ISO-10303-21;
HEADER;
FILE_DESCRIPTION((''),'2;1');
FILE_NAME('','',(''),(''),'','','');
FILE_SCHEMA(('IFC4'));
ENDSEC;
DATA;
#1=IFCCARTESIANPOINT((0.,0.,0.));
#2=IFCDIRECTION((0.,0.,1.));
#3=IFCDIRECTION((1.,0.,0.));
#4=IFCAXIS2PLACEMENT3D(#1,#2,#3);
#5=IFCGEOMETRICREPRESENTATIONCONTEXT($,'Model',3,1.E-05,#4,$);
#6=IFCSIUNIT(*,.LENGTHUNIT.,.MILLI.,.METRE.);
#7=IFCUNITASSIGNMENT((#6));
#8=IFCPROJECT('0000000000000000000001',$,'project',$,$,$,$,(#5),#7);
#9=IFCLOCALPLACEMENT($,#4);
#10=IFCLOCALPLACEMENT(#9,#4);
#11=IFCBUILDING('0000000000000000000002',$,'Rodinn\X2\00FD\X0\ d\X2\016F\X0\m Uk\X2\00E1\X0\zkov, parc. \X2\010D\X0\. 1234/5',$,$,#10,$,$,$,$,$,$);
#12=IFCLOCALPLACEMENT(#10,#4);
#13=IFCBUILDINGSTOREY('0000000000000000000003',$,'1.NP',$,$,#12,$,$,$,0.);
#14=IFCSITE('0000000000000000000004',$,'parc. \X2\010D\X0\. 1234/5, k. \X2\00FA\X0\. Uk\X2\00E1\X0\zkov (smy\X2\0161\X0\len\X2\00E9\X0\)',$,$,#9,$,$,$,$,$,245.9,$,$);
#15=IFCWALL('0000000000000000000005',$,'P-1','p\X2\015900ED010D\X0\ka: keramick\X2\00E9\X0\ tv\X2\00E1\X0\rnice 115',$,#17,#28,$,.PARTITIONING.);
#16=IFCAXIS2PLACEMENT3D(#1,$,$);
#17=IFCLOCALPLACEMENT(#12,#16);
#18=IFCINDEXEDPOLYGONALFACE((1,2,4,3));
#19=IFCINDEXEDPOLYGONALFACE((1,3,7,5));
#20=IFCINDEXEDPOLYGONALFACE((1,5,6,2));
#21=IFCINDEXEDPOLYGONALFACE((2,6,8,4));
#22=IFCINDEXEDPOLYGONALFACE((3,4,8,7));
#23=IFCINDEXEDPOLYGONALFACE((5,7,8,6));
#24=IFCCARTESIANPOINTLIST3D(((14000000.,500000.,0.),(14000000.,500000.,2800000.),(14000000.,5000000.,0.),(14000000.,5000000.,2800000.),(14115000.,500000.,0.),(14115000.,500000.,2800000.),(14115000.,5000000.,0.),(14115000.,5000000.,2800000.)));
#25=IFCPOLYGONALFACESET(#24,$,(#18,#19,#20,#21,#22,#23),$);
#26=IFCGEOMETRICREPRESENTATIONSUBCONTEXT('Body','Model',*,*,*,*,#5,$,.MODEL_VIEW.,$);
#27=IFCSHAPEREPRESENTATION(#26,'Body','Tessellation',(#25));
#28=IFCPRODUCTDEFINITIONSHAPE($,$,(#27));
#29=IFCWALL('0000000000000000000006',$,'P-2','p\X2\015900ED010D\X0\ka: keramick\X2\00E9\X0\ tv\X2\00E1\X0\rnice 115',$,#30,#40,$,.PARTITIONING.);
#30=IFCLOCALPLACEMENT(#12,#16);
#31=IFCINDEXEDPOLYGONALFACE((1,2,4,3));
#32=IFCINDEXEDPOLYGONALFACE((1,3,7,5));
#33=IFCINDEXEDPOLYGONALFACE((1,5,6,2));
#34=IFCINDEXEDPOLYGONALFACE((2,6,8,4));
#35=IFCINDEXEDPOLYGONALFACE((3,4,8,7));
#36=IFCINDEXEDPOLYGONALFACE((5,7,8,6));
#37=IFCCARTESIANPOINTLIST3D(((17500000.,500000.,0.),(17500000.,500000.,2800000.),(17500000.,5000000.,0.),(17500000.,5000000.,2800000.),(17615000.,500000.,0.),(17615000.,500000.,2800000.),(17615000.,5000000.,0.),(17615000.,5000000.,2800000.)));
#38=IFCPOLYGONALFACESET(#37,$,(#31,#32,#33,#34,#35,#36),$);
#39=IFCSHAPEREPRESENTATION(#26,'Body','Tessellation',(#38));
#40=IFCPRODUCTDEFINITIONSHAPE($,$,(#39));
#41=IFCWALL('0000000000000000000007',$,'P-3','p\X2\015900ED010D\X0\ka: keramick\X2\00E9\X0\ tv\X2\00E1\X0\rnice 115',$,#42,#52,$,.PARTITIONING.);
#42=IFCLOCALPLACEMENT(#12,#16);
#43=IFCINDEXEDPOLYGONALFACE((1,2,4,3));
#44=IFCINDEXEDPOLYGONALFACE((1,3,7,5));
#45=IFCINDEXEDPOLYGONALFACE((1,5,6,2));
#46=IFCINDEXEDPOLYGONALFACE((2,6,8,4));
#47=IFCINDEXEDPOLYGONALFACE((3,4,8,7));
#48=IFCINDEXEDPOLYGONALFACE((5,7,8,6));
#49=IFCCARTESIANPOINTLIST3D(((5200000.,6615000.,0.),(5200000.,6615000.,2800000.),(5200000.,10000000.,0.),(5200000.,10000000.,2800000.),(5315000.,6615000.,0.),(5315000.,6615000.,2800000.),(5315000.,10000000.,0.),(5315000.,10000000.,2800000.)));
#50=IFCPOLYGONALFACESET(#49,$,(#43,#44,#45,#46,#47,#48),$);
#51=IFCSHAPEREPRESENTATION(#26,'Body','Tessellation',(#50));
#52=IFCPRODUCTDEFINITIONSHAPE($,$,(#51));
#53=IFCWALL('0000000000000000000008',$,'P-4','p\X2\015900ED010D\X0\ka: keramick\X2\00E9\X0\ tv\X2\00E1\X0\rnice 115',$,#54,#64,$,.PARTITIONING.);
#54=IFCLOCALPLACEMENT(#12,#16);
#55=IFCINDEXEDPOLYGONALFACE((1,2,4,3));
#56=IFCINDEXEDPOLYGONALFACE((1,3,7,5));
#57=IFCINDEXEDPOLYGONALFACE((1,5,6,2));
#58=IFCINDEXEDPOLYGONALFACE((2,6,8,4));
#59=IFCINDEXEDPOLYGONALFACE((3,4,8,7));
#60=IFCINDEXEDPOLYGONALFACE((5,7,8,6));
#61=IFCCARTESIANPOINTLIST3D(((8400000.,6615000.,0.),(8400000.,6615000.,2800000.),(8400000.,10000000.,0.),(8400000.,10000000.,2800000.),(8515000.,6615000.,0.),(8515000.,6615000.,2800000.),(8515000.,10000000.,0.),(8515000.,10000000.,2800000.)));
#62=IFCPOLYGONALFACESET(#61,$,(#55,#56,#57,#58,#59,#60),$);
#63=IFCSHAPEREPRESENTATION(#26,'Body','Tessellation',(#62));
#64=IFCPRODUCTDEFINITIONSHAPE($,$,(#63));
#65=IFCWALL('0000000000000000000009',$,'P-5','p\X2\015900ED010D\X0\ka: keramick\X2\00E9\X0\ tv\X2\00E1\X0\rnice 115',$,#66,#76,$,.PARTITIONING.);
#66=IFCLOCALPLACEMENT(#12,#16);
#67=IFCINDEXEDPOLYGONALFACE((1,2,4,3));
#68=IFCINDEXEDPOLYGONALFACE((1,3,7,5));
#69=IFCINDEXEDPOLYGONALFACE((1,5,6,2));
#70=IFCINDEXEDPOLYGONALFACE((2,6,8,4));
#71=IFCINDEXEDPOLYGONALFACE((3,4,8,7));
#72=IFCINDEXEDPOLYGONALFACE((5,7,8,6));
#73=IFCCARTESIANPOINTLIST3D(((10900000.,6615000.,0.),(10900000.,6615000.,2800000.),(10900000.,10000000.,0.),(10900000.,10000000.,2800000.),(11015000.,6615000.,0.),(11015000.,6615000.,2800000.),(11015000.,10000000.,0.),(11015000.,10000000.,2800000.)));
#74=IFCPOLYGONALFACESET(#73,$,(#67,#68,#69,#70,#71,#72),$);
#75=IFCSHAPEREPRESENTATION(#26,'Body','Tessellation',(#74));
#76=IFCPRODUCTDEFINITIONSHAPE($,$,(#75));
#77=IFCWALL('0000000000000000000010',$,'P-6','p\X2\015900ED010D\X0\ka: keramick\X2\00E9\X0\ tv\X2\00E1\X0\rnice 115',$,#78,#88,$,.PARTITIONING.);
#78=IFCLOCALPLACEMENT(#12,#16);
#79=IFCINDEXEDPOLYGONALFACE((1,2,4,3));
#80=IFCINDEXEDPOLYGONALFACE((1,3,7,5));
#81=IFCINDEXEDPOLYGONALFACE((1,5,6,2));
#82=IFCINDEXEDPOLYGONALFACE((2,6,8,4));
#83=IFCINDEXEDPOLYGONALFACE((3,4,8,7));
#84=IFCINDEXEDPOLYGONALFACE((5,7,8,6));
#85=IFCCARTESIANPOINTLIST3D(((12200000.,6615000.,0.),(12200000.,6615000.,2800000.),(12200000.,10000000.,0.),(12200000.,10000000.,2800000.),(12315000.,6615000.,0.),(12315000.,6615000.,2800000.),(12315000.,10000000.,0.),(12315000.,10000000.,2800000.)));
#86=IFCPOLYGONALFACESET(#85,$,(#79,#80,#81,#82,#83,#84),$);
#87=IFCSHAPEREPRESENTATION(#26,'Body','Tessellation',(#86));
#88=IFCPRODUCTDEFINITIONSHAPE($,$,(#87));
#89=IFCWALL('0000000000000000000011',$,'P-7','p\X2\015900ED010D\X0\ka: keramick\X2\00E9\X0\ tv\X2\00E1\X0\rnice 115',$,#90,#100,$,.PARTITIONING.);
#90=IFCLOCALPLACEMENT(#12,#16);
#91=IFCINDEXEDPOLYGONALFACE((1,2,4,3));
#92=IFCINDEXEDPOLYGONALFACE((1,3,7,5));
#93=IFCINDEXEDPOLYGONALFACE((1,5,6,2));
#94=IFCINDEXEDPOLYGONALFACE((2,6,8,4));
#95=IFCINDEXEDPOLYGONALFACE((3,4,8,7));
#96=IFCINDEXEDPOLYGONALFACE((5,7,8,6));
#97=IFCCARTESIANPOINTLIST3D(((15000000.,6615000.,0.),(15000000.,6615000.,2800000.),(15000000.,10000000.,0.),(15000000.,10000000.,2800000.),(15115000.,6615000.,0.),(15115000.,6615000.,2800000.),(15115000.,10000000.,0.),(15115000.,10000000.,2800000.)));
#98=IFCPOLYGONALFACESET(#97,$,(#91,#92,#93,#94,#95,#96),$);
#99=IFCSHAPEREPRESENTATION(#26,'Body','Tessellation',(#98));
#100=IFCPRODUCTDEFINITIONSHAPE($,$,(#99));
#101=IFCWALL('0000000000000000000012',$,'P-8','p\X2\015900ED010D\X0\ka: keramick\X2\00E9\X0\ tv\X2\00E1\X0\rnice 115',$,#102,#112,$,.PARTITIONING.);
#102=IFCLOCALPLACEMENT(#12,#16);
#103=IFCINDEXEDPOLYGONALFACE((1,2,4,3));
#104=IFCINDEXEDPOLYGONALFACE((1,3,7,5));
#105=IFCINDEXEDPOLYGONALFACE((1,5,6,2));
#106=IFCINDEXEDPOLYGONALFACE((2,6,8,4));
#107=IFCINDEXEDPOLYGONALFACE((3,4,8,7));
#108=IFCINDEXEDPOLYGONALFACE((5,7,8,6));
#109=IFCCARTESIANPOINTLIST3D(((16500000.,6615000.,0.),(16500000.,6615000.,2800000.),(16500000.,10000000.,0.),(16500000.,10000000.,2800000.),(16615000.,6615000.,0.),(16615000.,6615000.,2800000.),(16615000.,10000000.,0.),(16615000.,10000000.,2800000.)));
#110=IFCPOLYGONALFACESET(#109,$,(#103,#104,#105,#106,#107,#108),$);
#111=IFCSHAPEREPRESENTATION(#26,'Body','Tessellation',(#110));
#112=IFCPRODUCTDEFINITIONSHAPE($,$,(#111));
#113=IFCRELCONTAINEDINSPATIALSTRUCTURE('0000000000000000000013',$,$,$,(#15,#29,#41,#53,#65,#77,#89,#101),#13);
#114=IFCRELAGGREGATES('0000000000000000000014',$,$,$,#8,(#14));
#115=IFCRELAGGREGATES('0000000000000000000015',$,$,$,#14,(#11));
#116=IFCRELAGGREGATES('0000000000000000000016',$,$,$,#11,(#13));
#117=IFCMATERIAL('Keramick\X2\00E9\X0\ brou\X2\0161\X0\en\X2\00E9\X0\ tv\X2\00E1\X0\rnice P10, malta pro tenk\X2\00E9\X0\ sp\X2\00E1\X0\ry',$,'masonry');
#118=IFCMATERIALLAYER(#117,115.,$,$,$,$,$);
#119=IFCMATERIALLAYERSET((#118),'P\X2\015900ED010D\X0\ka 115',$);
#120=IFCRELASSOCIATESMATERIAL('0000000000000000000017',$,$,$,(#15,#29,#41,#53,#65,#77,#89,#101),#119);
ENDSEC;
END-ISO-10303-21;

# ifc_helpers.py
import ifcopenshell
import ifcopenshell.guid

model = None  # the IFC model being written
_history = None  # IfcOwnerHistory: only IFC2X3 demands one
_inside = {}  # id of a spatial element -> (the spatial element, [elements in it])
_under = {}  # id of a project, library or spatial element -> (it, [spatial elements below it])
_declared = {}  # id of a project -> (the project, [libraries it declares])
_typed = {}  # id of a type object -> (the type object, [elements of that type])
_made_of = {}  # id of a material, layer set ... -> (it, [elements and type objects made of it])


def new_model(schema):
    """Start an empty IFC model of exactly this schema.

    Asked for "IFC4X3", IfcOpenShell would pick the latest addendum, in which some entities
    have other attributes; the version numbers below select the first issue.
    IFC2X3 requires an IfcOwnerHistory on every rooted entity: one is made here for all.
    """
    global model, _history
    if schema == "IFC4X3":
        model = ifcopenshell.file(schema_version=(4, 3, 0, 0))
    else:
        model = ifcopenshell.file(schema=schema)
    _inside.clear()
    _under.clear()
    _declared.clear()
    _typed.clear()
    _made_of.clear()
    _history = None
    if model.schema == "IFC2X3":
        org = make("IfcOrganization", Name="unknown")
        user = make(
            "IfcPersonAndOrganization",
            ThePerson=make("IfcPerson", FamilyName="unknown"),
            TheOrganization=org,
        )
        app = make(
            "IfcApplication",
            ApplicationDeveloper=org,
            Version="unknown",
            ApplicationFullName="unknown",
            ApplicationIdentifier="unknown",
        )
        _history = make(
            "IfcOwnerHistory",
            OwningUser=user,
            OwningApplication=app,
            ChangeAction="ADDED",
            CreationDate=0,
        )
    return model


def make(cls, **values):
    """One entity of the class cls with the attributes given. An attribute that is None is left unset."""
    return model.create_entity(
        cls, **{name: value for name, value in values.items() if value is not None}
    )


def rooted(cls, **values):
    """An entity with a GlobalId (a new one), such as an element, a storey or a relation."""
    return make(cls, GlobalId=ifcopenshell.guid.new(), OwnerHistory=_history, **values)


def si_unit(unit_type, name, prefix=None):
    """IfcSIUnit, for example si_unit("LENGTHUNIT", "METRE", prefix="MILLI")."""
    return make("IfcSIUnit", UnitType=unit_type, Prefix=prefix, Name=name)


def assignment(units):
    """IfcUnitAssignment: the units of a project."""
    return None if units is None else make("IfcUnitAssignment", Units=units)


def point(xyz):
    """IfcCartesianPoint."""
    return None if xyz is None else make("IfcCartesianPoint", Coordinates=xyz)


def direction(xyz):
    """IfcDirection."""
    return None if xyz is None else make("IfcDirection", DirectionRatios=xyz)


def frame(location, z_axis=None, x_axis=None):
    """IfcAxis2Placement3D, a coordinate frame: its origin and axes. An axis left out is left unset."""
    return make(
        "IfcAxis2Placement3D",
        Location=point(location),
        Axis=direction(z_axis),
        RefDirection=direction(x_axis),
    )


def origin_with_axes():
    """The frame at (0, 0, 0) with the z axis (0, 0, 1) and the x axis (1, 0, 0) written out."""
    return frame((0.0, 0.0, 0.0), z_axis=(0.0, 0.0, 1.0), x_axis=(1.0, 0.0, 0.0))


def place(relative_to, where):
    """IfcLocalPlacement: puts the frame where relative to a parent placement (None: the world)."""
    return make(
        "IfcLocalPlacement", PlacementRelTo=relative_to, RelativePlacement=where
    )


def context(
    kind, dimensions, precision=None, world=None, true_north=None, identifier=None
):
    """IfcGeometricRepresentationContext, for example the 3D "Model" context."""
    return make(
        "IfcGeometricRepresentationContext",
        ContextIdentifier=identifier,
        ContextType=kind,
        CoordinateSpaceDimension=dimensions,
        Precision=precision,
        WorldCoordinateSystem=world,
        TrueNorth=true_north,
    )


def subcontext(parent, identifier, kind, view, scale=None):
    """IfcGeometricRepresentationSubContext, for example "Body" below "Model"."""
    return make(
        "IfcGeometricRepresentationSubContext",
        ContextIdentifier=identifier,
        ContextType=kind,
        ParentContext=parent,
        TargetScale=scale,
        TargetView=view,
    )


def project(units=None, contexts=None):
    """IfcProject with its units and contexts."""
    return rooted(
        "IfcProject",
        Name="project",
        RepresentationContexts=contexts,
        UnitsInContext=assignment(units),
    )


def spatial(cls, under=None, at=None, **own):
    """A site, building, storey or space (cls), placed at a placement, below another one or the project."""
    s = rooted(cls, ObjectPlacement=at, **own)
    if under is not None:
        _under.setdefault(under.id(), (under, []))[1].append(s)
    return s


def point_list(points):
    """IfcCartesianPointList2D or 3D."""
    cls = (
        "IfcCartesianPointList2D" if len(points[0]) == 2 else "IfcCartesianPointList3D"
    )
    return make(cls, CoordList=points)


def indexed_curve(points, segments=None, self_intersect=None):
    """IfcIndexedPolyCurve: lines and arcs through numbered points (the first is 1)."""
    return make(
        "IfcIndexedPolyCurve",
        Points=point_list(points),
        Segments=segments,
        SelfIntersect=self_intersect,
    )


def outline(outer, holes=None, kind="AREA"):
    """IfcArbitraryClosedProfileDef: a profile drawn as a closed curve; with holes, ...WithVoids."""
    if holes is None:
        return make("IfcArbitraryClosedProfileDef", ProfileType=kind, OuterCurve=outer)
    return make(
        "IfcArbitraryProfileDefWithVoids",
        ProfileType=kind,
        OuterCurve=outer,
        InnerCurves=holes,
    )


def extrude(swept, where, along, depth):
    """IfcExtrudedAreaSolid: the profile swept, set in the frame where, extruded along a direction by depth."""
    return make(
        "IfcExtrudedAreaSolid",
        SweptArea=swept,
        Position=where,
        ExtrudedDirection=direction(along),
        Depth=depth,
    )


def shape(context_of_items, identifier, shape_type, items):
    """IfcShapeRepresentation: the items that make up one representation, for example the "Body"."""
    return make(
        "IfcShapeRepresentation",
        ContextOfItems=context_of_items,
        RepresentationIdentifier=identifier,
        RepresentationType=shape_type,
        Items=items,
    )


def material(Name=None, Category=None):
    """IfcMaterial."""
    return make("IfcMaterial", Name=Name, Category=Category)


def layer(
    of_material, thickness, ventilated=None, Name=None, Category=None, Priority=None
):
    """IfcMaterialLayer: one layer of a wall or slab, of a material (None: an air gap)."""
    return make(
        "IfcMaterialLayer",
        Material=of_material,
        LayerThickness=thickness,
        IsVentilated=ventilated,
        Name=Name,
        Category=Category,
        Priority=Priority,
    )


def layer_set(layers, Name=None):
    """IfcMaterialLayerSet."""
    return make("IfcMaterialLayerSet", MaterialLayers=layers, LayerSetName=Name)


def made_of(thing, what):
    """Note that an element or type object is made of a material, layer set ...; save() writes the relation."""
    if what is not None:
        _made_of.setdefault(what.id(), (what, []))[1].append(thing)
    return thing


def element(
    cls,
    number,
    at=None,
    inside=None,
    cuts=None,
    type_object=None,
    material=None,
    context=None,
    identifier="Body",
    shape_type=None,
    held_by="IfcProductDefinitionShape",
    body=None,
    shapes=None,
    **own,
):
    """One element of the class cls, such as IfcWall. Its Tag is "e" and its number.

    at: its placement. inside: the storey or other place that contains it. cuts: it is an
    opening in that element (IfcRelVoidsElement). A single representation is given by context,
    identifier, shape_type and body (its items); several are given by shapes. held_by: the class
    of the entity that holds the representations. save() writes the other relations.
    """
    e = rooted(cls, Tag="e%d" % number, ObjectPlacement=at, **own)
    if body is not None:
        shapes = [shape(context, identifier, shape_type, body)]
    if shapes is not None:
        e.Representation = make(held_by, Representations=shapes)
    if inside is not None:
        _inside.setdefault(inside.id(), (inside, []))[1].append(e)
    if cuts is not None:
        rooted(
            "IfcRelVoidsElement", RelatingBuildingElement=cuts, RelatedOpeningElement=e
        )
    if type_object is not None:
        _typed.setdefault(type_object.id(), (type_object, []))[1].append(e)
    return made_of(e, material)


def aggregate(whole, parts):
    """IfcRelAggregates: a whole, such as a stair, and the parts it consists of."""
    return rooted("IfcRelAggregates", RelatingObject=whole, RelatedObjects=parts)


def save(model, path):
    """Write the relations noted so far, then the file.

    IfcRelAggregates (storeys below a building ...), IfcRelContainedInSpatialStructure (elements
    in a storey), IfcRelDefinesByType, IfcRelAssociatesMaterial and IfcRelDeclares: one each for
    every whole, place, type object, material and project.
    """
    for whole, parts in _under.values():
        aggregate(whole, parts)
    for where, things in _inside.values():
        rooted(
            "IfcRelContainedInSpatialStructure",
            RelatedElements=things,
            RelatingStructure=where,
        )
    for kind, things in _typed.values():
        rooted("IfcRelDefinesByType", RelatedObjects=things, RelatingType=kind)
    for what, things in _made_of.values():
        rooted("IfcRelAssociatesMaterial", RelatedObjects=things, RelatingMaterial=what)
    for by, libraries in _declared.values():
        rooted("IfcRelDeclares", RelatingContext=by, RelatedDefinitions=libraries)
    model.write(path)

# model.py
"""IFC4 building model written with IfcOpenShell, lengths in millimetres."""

from ifc_helpers import new_model, si_unit, frame, origin_with_axes, place, context, subcontext, project, spatial, indexed_curve, outline, extrude, material, layer, layer_set, element, save


model = new_model("IFC4")

# Units and contexts
model_context = context("Model", 3, precision=1e-05, world=origin_with_axes())
body_context = subcontext(model_context, "Body", "Model", "MODEL_VIEW")
ifc_project = project(units=[si_unit("LENGTHUNIT", "METRE", prefix="MILLI")], contexts=[model_context])

# Site, building, storey
site_placement = place(None, origin_with_axes())
site = spatial("IfcSite", under=ifc_project, at=site_placement, Name="parc. č. 1234/5, k. ú. Ukázkov (smyšlené)", RefElevation=245.9)
building_placement = place(site_placement, origin_with_axes())
building = spatial("IfcBuilding", under=site, at=building_placement, Name="Rodinný dům Ukázkov, parc. č. 1234/5")
storey_placement = place(building_placement, origin_with_axes())
storey = spatial("IfcBuildingStorey", under=building, at=storey_placement, Name="1.NP", Elevation=0.0)

# Shared definitions
ifc_material_1 = material(Name="Keramické broušené tvárnice P10, malta pro tenké spáry", Category="masonry")

# Walls
ifc_layer_1 = layer(ifc_material_1, 115.0)
ifc_layer_set_1 = layer_set([ifc_layer_1], Name="Příčka 115")
for number, where, z_axis, x_axis, name in (
    (1, (14115000.0, 500000.0, 0.0), (0.0, 0.0, 1.0), (0.0, 1.0, 0.0), "P-1"),
    (2, (17615000.0, 500000.0, 0.0), (0.0, 0.0, 1.0), (0.0, 1.0, 0.0), "P-2"),
):
    element("IfcWall", number, at=place(storey_placement, frame(where, z_axis=z_axis, x_axis=x_axis)), inside=storey, material=ifc_layer_set_1, Name=name, Description="příčka: keramické tvárnice 115", PredefinedType="PARTITIONING", context=body_context, shape_type="SweptSolid", body=[
        extrude(outline(indexed_curve([(0.0, 0.0), (0.0, 115000.0), (4500000.0, 115000.0), (4500000.0, 0.0), (0.0, 0.0)], self_intersect=False)), origin_with_axes(), (0.0, 0.0, 1.0), 2800000.0),
    ])
for number, where, z_axis, x_axis, name in (
    (3, (5315000.0, 6615000.0, 0.0), (0.0, 0.0, 1.0), (0.0, 1.0, 0.0), "P-3"),
    (4, (8515000.0, 6615000.0, 0.0), (0.0, 0.0, 1.0), (0.0, 1.0, 0.0), "P-4"),
    (5, (11015000.0, 6615000.0, 0.0), (0.0, 0.0, 1.0), (0.0, 1.0, 0.0), "P-5"),
    (6, (12315000.0, 6615000.0, 0.0), (0.0, 0.0, 1.0), (0.0, 1.0, 0.0), "P-6"),
    (7, (15115000.0, 6615000.0, 0.0), (0.0, 0.0, 1.0), (0.0, 1.0, 0.0), "P-7"),
    (8, (16615000.0, 6615000.0, 0.0), (0.0, 0.0, 1.0), (0.0, 1.0, 0.0), "P-8"),
):
    element("IfcWall", number, at=place(storey_placement, frame(where, z_axis=z_axis, x_axis=x_axis)), inside=storey, material=ifc_layer_set_1, Name=name, Description="příčka: keramické tvárnice 115", PredefinedType="PARTITIONING", context=body_context, shape_type="SweptSolid", body=[
        extrude(outline(indexed_curve([(0.0, 0.0), (0.0, 115000.0), (3385000.0, 115000.0), (3385000.0, 0.0), (0.0, 0.0)], self_intersect=False)), origin_with_axes(), (0.0, 0.0, 1.0), 2800000.0),
    ])

save(model, "model.ifc")
